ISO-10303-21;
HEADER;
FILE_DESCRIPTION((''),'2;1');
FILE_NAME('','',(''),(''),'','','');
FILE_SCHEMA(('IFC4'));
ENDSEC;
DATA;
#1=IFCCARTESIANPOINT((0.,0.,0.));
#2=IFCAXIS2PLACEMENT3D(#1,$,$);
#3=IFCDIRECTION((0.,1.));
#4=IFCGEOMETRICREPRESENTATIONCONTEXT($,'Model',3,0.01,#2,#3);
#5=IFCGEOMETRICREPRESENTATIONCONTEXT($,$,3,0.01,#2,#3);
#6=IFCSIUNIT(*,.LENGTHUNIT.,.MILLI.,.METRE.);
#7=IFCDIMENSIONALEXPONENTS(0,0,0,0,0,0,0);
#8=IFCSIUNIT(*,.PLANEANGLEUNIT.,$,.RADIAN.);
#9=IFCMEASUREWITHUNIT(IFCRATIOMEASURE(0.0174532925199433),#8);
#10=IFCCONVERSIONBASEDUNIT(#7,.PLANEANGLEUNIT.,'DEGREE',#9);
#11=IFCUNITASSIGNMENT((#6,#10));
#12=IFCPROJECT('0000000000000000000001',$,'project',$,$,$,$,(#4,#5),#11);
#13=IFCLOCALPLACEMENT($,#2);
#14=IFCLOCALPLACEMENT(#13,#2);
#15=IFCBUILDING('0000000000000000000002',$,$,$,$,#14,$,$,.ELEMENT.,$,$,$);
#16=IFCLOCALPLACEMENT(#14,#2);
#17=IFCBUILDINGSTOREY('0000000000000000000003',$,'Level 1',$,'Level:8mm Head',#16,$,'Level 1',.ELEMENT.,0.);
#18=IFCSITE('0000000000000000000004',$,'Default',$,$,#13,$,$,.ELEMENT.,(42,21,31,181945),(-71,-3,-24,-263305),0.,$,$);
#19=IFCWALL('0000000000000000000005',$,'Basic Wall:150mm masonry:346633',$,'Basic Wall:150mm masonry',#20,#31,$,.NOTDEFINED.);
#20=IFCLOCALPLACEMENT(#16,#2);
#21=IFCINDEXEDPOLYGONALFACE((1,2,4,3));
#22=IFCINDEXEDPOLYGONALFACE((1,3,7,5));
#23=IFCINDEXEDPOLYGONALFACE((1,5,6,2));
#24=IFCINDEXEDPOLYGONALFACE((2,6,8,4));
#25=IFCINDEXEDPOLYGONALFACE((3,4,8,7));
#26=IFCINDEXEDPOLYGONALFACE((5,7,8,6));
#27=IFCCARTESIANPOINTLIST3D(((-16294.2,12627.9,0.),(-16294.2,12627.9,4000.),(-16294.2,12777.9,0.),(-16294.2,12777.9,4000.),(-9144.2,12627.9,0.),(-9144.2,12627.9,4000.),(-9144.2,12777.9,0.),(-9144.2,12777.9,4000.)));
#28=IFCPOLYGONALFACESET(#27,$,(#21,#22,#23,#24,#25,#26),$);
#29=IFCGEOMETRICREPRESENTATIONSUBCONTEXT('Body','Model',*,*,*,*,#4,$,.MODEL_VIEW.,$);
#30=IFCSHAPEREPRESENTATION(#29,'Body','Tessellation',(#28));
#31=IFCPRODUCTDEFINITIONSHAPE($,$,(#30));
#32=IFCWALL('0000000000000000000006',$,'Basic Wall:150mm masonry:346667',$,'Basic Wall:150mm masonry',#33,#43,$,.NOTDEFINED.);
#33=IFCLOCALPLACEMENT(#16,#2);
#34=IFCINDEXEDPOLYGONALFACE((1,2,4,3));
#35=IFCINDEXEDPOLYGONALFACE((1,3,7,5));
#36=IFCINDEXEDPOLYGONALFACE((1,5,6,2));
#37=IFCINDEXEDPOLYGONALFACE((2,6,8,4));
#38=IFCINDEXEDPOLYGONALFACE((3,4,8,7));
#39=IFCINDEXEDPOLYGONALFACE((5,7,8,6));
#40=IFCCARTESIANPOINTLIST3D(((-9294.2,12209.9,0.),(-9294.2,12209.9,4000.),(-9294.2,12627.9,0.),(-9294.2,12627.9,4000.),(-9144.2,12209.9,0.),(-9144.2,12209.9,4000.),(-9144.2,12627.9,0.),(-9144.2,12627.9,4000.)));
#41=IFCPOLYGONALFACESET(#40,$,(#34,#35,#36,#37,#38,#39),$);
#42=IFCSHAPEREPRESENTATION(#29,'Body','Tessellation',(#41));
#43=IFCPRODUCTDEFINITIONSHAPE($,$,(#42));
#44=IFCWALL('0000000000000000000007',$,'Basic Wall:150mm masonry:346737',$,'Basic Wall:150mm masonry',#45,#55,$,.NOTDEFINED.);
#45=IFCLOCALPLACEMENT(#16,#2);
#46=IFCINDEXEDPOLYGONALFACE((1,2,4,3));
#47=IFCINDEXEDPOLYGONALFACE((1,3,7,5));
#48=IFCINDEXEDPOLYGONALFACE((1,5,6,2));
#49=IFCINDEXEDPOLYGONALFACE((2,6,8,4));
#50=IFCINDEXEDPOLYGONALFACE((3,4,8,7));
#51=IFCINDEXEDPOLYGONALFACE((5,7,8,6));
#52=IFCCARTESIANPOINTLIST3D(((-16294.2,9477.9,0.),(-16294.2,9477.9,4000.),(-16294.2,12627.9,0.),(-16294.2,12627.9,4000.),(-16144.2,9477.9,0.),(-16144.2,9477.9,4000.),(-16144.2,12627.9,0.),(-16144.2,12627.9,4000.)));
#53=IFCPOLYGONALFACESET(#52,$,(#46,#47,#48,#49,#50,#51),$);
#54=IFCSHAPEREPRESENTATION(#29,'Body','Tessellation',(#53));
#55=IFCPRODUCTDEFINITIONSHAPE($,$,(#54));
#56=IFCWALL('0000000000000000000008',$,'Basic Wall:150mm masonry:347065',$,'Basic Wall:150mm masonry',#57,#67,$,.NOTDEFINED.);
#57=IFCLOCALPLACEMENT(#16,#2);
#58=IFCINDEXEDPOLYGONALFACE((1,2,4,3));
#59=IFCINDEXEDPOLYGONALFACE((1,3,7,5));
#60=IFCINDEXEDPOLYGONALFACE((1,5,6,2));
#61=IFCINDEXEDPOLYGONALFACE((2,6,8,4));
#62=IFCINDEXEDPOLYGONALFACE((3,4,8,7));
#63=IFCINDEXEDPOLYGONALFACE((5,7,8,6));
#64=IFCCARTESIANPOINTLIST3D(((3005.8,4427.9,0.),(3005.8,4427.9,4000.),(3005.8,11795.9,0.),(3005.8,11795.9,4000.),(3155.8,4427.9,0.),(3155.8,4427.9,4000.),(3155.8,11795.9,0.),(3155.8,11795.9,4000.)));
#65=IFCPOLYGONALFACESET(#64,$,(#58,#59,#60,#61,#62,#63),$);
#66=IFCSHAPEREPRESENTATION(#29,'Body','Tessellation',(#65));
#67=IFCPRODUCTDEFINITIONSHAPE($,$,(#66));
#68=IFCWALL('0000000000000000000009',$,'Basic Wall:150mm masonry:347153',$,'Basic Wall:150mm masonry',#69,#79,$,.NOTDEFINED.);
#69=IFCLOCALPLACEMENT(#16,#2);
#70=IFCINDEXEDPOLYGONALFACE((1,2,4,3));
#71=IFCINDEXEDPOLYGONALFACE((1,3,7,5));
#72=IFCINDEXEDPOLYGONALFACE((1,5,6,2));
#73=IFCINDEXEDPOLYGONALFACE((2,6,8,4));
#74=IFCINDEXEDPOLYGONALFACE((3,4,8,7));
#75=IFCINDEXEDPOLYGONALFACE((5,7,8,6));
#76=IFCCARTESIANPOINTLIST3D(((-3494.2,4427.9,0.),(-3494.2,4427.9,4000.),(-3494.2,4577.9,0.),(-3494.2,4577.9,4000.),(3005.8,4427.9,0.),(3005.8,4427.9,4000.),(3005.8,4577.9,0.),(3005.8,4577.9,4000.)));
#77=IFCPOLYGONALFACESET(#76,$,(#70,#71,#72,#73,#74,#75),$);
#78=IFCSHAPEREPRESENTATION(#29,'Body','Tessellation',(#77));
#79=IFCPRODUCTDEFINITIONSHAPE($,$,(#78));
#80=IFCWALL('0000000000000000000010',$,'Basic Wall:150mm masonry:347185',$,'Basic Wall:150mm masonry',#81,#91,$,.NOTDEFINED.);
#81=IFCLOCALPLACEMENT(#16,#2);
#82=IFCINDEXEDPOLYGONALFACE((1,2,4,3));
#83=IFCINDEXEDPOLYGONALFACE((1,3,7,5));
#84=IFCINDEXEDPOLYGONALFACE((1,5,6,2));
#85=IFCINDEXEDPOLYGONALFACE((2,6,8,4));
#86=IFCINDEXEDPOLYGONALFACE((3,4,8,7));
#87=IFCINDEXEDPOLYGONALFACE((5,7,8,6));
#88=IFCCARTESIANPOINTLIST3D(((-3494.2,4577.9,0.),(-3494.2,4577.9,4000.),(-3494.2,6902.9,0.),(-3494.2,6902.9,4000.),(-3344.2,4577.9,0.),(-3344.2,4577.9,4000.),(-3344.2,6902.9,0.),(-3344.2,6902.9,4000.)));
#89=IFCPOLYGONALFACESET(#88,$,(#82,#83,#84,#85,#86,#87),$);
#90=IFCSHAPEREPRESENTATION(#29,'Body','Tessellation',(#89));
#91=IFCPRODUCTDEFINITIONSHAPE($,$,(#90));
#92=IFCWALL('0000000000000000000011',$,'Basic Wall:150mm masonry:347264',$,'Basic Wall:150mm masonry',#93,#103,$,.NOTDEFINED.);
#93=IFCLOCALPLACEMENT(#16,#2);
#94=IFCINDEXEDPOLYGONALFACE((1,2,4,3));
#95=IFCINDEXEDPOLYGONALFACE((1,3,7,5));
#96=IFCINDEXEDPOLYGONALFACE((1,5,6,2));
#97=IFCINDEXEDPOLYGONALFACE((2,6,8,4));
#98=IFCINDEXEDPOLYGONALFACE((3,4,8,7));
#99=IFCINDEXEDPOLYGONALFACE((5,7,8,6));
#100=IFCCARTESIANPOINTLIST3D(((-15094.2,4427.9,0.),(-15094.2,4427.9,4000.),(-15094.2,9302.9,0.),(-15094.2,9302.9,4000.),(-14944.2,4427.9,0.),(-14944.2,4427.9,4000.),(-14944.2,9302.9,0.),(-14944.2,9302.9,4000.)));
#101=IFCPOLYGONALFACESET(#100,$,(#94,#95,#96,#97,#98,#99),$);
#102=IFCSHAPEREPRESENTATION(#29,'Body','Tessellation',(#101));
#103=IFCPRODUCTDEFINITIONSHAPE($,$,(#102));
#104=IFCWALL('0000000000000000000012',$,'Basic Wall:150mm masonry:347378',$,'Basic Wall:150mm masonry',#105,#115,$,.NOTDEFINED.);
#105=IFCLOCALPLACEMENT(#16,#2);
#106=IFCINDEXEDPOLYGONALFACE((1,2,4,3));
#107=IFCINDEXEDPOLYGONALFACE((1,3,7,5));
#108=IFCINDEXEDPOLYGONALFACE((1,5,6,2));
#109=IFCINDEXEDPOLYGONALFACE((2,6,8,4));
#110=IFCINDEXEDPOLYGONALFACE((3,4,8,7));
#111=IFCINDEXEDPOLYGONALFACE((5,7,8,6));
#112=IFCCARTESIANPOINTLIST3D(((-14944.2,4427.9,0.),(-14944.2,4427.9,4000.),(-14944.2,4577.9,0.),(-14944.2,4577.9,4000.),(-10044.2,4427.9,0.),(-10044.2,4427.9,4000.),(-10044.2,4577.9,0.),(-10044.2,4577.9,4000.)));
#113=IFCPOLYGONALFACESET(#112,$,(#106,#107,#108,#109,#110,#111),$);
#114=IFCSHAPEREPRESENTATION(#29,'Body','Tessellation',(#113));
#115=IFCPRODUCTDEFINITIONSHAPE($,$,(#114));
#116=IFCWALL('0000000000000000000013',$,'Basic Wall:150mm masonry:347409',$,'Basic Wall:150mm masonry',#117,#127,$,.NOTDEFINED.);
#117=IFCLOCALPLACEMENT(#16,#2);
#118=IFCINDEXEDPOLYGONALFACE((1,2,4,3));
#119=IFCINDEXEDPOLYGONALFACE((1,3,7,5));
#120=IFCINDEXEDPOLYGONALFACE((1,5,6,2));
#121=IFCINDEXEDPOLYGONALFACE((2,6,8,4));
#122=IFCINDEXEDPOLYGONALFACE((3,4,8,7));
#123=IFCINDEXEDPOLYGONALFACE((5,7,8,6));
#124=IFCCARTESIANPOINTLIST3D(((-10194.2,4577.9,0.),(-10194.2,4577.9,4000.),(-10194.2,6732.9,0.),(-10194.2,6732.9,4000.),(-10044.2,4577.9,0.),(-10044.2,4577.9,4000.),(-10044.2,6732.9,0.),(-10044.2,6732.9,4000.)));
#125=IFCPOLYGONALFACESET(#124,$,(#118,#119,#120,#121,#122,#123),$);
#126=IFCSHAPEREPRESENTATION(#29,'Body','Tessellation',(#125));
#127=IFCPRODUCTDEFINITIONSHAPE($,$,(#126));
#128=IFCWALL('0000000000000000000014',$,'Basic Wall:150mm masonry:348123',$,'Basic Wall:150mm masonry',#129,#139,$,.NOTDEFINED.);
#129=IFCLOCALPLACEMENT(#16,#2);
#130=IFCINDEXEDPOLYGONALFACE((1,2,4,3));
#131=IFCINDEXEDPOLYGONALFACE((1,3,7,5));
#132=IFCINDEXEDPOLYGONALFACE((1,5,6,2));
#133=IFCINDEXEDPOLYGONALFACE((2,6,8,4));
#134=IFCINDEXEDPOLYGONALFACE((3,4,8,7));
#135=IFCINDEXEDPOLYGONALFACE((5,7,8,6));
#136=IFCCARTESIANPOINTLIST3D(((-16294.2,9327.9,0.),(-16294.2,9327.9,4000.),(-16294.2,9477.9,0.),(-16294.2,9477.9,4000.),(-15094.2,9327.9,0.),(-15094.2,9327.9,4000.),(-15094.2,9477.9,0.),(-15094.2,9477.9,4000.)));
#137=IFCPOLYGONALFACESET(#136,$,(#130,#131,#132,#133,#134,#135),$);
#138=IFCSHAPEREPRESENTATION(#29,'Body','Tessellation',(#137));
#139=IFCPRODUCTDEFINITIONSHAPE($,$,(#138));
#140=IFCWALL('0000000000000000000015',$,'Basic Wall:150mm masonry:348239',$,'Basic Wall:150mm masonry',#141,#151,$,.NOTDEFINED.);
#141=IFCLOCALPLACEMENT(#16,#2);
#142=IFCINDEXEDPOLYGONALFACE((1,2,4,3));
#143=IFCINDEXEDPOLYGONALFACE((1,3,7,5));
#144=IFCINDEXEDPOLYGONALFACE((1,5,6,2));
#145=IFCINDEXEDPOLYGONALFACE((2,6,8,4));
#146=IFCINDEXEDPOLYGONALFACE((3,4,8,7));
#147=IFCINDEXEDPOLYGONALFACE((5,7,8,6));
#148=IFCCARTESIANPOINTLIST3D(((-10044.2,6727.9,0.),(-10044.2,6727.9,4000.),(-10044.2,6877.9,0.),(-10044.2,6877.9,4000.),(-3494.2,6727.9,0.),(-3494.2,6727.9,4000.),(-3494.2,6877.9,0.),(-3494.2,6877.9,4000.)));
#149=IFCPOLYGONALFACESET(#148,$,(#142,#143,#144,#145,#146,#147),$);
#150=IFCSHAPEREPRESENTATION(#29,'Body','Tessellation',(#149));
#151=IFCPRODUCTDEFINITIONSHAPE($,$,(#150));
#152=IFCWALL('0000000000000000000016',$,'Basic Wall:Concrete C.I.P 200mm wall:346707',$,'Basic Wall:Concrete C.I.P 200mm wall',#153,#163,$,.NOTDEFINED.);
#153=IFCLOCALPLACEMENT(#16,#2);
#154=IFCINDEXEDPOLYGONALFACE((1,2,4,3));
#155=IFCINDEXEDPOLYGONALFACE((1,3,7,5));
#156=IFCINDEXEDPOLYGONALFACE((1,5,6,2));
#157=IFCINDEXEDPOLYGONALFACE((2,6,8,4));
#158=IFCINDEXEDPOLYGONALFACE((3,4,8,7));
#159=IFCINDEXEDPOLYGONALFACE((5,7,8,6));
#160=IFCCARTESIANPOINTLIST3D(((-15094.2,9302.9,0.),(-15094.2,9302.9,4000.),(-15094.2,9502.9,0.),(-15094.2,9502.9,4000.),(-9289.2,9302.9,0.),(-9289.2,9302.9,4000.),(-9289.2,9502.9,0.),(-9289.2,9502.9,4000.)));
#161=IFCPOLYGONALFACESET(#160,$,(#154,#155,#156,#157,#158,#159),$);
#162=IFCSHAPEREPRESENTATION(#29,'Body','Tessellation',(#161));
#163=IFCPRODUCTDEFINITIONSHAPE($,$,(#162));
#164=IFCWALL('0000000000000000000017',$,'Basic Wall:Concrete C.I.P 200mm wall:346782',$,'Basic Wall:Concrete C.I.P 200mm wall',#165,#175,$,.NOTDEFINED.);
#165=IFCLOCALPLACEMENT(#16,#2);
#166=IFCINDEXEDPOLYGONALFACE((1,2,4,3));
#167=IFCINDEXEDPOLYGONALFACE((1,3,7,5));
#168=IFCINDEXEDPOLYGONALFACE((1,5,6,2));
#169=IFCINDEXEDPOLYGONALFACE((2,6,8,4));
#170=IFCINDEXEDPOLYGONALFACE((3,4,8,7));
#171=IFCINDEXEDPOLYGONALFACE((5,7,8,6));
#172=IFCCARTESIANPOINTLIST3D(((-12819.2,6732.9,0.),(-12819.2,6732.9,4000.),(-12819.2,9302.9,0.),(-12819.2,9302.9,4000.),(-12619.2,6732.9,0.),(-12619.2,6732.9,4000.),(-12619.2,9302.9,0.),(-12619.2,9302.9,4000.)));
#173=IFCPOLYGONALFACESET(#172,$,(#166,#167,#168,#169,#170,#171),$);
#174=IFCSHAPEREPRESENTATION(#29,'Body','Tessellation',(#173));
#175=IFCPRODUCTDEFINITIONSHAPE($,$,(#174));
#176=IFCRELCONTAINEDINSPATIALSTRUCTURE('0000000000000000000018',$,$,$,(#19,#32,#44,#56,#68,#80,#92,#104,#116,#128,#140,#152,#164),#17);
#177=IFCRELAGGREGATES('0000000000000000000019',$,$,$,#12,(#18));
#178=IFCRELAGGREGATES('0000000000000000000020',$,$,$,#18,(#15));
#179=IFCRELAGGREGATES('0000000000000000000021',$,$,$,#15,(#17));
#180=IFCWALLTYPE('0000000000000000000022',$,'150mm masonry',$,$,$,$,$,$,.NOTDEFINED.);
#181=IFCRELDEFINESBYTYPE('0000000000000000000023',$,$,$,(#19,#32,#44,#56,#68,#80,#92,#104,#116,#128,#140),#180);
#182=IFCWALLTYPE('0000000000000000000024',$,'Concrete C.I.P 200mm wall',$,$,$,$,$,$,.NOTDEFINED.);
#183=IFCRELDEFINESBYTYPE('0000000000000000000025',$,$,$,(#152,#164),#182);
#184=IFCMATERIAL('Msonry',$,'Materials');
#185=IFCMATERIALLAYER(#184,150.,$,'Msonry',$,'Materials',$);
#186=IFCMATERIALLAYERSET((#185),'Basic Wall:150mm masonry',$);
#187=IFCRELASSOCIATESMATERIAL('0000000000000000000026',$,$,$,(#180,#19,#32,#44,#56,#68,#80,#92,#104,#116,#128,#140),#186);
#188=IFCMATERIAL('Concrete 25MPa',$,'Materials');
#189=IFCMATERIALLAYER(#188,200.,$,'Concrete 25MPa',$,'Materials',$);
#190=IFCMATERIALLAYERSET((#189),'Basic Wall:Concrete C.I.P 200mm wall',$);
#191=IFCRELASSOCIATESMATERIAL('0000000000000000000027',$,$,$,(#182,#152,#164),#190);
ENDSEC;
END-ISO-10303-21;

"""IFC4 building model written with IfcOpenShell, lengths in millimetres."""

from ifc_helpers import new_model, entity, si_unit, converted_unit, direction, frame, frame_2d, origin, place, context, subcontext, project, spatial, rectangle, extrude, material, layer, layer_set, layer_usage, type_object, element, save


model = new_model("IFC4")

# Units and contexts
model_context = context("Model", 3, precision=0.01, world=origin(), true_north=direction((0.0, 1.0)))
context_of_model = context(None, 3, precision=0.01, world=origin(), true_north=direction((0.0, 1.0)))
body_context = subcontext(model_context, "Body", "Model", "MODEL_VIEW")
ifc_project = project(units=[si_unit("LENGTHUNIT", "METRE", prefix="MILLI"), converted_unit("PLANEANGLEUNIT", "DEGREE", entity("IfcRatioMeasure", 0.0174532925199433), si_unit("PLANEANGLEUNIT", "RADIAN"), dimensions=[0, 0, 0, 0, 0, 0, 0])], contexts=[model_context, context_of_model])

# Site, building, storey
site_placement = place(None, origin())
site = spatial("IfcSite", under=ifc_project, at=site_placement, Name="Default", CompositionType="ELEMENT", RefLatitude=(42, 21, 31, 181945), RefLongitude=(-71, -3, -24, -263305), RefElevation=0.0)
building_placement = place(site_placement, origin())
building = spatial("IfcBuilding", under=site, at=building_placement, CompositionType="ELEMENT")
storey_placement = place(building_placement, origin())
storey = spatial("IfcBuildingStorey", under=building, at=storey_placement, Name="Level 1", ObjectType="Level:8mm Head", LongName="Level 1", CompositionType="ELEMENT", Elevation=0.0)

# Walls
ifc_material_1 = material(Name="Msonry", Category="Materials")
ifc_layer_1 = layer(ifc_material_1, 150.0, Name="Msonry", Category="Materials")
ifc_layer_set_1 = layer_set([ifc_layer_1], Name="Basic Wall:150mm masonry")
ifc_layer_usage_1 = layer_usage(ifc_layer_set_1, "AXIS2", "NEGATIVE", 75.0)
wall_type_1 = type_object("IfcWallType", Name="150mm masonry", PredefinedType="NOTDEFINED", material=ifc_layer_set_1)
wall_1_placement = place(storey_placement, frame((-16294.2, 12702.9, 0.0)))
element("IfcWall", 1, at=wall_1_placement, inside=storey, type_object=wall_type_1, material=ifc_layer_usage_1, Name="Basic Wall:150mm masonry:346633", ObjectType="Basic Wall:150mm masonry", PredefinedType="NOTDEFINED", context=body_context, shape_type="SweptSolid", body=[
    extrude(rectangle(XDim=7150.0, YDim=150.0, at=frame_2d((3575.0, 0.0), x_axis=(-1.0, 0.0))), origin(), (0.0, 0.0, 1.0), 4000.0),
])
ifc_layer_usage_2 = layer_usage(ifc_layer_set_1, "AXIS2", "NEGATIVE", 75.0)
wall_2_placement = place(storey_placement, frame((-9219.2, 12627.9, 0.0), z_axis=(0.0, 0.0, 1.0), x_axis=(0.0, -1.0, 0.0)))
element("IfcWall", 2, at=wall_2_placement, inside=storey, type_object=wall_type_1, material=ifc_layer_usage_2, Name="Basic Wall:150mm masonry:346667", ObjectType="Basic Wall:150mm masonry", PredefinedType="NOTDEFINED", context=body_context, shape_type="SweptSolid", body=[
    extrude(rectangle(XDim=418.0, YDim=150.0, at=frame_2d((209.0, 0.0), x_axis=(-1.0, 0.0))), origin(), (0.0, 0.0, 1.0), 4000.0),
])
ifc_layer_usage_3 = layer_usage(ifc_layer_set_1, "AXIS2", "NEGATIVE", 75.0)
wall_3_placement = place(storey_placement, frame((-16219.2, 9477.9, 0.0), z_axis=(0.0, 0.0, 1.0), x_axis=(0.0, 1.0, 0.0)))
element("IfcWall", 3, at=wall_3_placement, inside=storey, type_object=wall_type_1, material=ifc_layer_usage_3, Name="Basic Wall:150mm masonry:346737", ObjectType="Basic Wall:150mm masonry", PredefinedType="NOTDEFINED", context=body_context, shape_type="SweptSolid", body=[
    extrude(rectangle(XDim=3150.0, YDim=150.0, at=frame_2d((1575.0, 0.0), x_axis=(-1.0, 0.0))), origin(), (0.0, 0.0, 1.0), 4000.0),
])
ifc_layer_usage_4 = layer_usage(ifc_layer_set_1, "AXIS2", "NEGATIVE", 75.0)
wall_4_placement = place(storey_placement, frame((3080.8, 11795.9, 0.0), z_axis=(0.0, 0.0, 1.0), x_axis=(0.0, -1.0, 0.0)))
element("IfcWall", 4, at=wall_4_placement, inside=storey, type_object=wall_type_1, material=ifc_layer_usage_4, Name="Basic Wall:150mm masonry:347065", ObjectType="Basic Wall:150mm masonry", PredefinedType="NOTDEFINED", context=body_context, shape_type="SweptSolid", body=[
    extrude(rectangle(XDim=7368.0, YDim=150.0, at=frame_2d((3684.0, 0.0), x_axis=(-1.0, 0.0))), origin(), (0.0, 0.0, 1.0), 4000.0),
])
ifc_layer_usage_5 = layer_usage(ifc_layer_set_1, "AXIS2", "NEGATIVE", 75.0)
wall_5_placement = place(storey_placement, frame((3005.8, 4502.9, 0.0), z_axis=(0.0, 0.0, 1.0), x_axis=(-1.0, 0.0, 0.0)))
element("IfcWall", 5, at=wall_5_placement, inside=storey, type_object=wall_type_1, material=ifc_layer_usage_5, Name="Basic Wall:150mm masonry:347153", ObjectType="Basic Wall:150mm masonry", PredefinedType="NOTDEFINED", context=body_context, shape_type="SweptSolid", body=[
    extrude(rectangle(XDim=6500.0, YDim=150.0, at=frame_2d((3250.0, 0.0), x_axis=(-1.0, 0.0))), origin(), (0.0, 0.0, 1.0), 4000.0),
])
ifc_layer_usage_6 = layer_usage(ifc_layer_set_1, "AXIS2", "NEGATIVE", 75.0)
wall_6_placement = place(storey_placement, frame((-3419.2, 4577.9, 0.0), z_axis=(0.0, 0.0, 1.0), x_axis=(0.0, 1.0, 0.0)))
element("IfcWall", 6, at=wall_6_placement, inside=storey, type_object=wall_type_1, material=ifc_layer_usage_6, Name="Basic Wall:150mm masonry:347185", ObjectType="Basic Wall:150mm masonry", PredefinedType="NOTDEFINED", context=body_context, shape_type="SweptSolid", body=[
    extrude(rectangle(XDim=2325.0, YDim=150.0, at=frame_2d((1162.5, 0.0), x_axis=(-1.0, 0.0))), origin(), (0.0, 0.0, 1.0), 4000.0),
])
ifc_layer_usage_7 = layer_usage(ifc_layer_set_1, "AXIS2", "NEGATIVE", 75.0)
wall_7_placement = place(storey_placement, frame((-15019.2, 9302.9, 0.0), z_axis=(0.0, 0.0, 1.0), x_axis=(0.0, -1.0, 0.0)))
element("IfcWall", 7, at=wall_7_placement, inside=storey, type_object=wall_type_1, material=ifc_layer_usage_7, Name="Basic Wall:150mm masonry:347264", ObjectType="Basic Wall:150mm masonry", PredefinedType="NOTDEFINED", context=body_context, shape_type="SweptSolid", body=[
    extrude(rectangle(XDim=4875.0, YDim=150.0, at=frame_2d((2437.5, 0.0), x_axis=(-1.0, 0.0))), origin(), (0.0, 0.0, 1.0), 4000.0),
])
ifc_layer_usage_8 = layer_usage(ifc_layer_set_1, "AXIS2", "NEGATIVE", 75.0)
wall_8_placement = place(storey_placement, frame((-14944.2, 4502.9, 0.0)))
element("IfcWall", 8, at=wall_8_placement, inside=storey, type_object=wall_type_1, material=ifc_layer_usage_8, Name="Basic Wall:150mm masonry:347378", ObjectType="Basic Wall:150mm masonry", PredefinedType="NOTDEFINED", context=body_context, shape_type="SweptSolid", body=[
    extrude(rectangle(XDim=4900.0, YDim=150.0, at=frame_2d((2450.0, 0.0), x_axis=(-1.0, 0.0))), origin(), (0.0, 0.0, 1.0), 4000.0),
])
ifc_layer_usage_9 = layer_usage(ifc_layer_set_1, "AXIS2", "NEGATIVE", 75.0)
wall_9_placement = place(storey_placement, frame((-10119.2, 4577.9, 0.0), z_axis=(0.0, 0.0, 1.0), x_axis=(0.0, 1.0, 0.0)))
element("IfcWall", 9, at=wall_9_placement, inside=storey, type_object=wall_type_1, material=ifc_layer_usage_9, Name="Basic Wall:150mm masonry:347409", ObjectType="Basic Wall:150mm masonry", PredefinedType="NOTDEFINED", context=body_context, shape_type="SweptSolid", body=[
    extrude(rectangle(XDim=2155.0, YDim=150.0, at=frame_2d((1077.5, 0.0), x_axis=(-1.0, 0.0))), origin(), (0.0, 0.0, 1.0), 4000.0),
])
ifc_layer_usage_10 = layer_usage(ifc_layer_set_1, "AXIS2", "NEGATIVE", 75.0)
wall_10_placement = place(storey_placement, frame((-15094.2, 9402.9, 0.0), z_axis=(0.0, 0.0, 1.0), x_axis=(-1.0, 0.0, 0.0)))
element("IfcWall", 10, at=wall_10_placement, inside=storey, type_object=wall_type_1, material=ifc_layer_usage_10, Name="Basic Wall:150mm masonry:348123", ObjectType="Basic Wall:150mm masonry", PredefinedType="NOTDEFINED", context=body_context, shape_type="SweptSolid", body=[
    extrude(rectangle(XDim=1200.0, YDim=150.0, at=frame_2d((600.0, 0.0), x_axis=(-1.0, 0.0))), origin(), (0.0, 0.0, 1.0), 4000.0),
])
ifc_layer_usage_11 = layer_usage(ifc_layer_set_1, "AXIS2", "NEGATIVE", 75.0)
wall_11_placement = place(storey_placement, frame((-10044.2, 6802.9, 0.0)))
element("IfcWall", 11, at=wall_11_placement, inside=storey, type_object=wall_type_1, material=ifc_layer_usage_11, Name="Basic Wall:150mm masonry:348239", ObjectType="Basic Wall:150mm masonry", PredefinedType="NOTDEFINED", context=body_context, shape_type="SweptSolid", body=[
    extrude(rectangle(XDim=6550.0, YDim=150.0, at=frame_2d((3275.0, 0.0), x_axis=(-1.0, 0.0))), origin(), (0.0, 0.0, 1.0), 4000.0),
])
ifc_material_2 = material(Name="Concrete 25MPa", Category="Materials")
ifc_layer_2 = layer(ifc_material_2, 200.0, Name="Concrete 25MPa", Category="Materials")
ifc_layer_set_2 = layer_set([ifc_layer_2], Name="Basic Wall:Concrete C.I.P 200mm wall")
ifc_layer_usage_12 = layer_usage(ifc_layer_set_2, "AXIS2", "NEGATIVE", 100.0)
wall_type_2 = type_object("IfcWallType", Name="Concrete C.I.P 200mm wall", PredefinedType="NOTDEFINED", material=ifc_layer_set_2)
wall_12_placement = place(storey_placement, frame((-9289.2, 9402.9, 0.0), z_axis=(0.0, 0.0, 1.0), x_axis=(-1.0, 0.0, 0.0)))
element("IfcWall", 12, at=wall_12_placement, inside=storey, type_object=wall_type_2, material=ifc_layer_usage_12, Name="Basic Wall:Concrete C.I.P 200mm wall:346707", ObjectType="Basic Wall:Concrete C.I.P 200mm wall", PredefinedType="NOTDEFINED", context=body_context, shape_type="SweptSolid", body=[
    extrude(rectangle(XDim=5805.0, YDim=200.0, at=frame_2d((2902.5, 0.0), x_axis=(-1.0, 0.0))), origin(), (0.0, 0.0, 1.0), 4000.0),
])
ifc_layer_usage_13 = layer_usage(ifc_layer_set_2, "AXIS2", "NEGATIVE", 100.0)
wall_13_placement = place(storey_placement, frame((-12719.2, 9302.9, 0.0), z_axis=(0.0, 0.0, 1.0), x_axis=(0.0, -1.0, 0.0)))
element("IfcWall", 13, at=wall_13_placement, inside=storey, type_object=wall_type_2, material=ifc_layer_usage_13, Name="Basic Wall:Concrete C.I.P 200mm wall:346782", ObjectType="Basic Wall:Concrete C.I.P 200mm wall", PredefinedType="NOTDEFINED", context=body_context, shape_type="SweptSolid", body=[
    extrude(rectangle(XDim=2570.0, YDim=200.0, at=frame_2d((1285.0, 0.0), x_axis=(-1.0, 0.0))), origin(), (0.0, 0.0, 1.0), 4000.0),
])

save(model, "model.ifc")
